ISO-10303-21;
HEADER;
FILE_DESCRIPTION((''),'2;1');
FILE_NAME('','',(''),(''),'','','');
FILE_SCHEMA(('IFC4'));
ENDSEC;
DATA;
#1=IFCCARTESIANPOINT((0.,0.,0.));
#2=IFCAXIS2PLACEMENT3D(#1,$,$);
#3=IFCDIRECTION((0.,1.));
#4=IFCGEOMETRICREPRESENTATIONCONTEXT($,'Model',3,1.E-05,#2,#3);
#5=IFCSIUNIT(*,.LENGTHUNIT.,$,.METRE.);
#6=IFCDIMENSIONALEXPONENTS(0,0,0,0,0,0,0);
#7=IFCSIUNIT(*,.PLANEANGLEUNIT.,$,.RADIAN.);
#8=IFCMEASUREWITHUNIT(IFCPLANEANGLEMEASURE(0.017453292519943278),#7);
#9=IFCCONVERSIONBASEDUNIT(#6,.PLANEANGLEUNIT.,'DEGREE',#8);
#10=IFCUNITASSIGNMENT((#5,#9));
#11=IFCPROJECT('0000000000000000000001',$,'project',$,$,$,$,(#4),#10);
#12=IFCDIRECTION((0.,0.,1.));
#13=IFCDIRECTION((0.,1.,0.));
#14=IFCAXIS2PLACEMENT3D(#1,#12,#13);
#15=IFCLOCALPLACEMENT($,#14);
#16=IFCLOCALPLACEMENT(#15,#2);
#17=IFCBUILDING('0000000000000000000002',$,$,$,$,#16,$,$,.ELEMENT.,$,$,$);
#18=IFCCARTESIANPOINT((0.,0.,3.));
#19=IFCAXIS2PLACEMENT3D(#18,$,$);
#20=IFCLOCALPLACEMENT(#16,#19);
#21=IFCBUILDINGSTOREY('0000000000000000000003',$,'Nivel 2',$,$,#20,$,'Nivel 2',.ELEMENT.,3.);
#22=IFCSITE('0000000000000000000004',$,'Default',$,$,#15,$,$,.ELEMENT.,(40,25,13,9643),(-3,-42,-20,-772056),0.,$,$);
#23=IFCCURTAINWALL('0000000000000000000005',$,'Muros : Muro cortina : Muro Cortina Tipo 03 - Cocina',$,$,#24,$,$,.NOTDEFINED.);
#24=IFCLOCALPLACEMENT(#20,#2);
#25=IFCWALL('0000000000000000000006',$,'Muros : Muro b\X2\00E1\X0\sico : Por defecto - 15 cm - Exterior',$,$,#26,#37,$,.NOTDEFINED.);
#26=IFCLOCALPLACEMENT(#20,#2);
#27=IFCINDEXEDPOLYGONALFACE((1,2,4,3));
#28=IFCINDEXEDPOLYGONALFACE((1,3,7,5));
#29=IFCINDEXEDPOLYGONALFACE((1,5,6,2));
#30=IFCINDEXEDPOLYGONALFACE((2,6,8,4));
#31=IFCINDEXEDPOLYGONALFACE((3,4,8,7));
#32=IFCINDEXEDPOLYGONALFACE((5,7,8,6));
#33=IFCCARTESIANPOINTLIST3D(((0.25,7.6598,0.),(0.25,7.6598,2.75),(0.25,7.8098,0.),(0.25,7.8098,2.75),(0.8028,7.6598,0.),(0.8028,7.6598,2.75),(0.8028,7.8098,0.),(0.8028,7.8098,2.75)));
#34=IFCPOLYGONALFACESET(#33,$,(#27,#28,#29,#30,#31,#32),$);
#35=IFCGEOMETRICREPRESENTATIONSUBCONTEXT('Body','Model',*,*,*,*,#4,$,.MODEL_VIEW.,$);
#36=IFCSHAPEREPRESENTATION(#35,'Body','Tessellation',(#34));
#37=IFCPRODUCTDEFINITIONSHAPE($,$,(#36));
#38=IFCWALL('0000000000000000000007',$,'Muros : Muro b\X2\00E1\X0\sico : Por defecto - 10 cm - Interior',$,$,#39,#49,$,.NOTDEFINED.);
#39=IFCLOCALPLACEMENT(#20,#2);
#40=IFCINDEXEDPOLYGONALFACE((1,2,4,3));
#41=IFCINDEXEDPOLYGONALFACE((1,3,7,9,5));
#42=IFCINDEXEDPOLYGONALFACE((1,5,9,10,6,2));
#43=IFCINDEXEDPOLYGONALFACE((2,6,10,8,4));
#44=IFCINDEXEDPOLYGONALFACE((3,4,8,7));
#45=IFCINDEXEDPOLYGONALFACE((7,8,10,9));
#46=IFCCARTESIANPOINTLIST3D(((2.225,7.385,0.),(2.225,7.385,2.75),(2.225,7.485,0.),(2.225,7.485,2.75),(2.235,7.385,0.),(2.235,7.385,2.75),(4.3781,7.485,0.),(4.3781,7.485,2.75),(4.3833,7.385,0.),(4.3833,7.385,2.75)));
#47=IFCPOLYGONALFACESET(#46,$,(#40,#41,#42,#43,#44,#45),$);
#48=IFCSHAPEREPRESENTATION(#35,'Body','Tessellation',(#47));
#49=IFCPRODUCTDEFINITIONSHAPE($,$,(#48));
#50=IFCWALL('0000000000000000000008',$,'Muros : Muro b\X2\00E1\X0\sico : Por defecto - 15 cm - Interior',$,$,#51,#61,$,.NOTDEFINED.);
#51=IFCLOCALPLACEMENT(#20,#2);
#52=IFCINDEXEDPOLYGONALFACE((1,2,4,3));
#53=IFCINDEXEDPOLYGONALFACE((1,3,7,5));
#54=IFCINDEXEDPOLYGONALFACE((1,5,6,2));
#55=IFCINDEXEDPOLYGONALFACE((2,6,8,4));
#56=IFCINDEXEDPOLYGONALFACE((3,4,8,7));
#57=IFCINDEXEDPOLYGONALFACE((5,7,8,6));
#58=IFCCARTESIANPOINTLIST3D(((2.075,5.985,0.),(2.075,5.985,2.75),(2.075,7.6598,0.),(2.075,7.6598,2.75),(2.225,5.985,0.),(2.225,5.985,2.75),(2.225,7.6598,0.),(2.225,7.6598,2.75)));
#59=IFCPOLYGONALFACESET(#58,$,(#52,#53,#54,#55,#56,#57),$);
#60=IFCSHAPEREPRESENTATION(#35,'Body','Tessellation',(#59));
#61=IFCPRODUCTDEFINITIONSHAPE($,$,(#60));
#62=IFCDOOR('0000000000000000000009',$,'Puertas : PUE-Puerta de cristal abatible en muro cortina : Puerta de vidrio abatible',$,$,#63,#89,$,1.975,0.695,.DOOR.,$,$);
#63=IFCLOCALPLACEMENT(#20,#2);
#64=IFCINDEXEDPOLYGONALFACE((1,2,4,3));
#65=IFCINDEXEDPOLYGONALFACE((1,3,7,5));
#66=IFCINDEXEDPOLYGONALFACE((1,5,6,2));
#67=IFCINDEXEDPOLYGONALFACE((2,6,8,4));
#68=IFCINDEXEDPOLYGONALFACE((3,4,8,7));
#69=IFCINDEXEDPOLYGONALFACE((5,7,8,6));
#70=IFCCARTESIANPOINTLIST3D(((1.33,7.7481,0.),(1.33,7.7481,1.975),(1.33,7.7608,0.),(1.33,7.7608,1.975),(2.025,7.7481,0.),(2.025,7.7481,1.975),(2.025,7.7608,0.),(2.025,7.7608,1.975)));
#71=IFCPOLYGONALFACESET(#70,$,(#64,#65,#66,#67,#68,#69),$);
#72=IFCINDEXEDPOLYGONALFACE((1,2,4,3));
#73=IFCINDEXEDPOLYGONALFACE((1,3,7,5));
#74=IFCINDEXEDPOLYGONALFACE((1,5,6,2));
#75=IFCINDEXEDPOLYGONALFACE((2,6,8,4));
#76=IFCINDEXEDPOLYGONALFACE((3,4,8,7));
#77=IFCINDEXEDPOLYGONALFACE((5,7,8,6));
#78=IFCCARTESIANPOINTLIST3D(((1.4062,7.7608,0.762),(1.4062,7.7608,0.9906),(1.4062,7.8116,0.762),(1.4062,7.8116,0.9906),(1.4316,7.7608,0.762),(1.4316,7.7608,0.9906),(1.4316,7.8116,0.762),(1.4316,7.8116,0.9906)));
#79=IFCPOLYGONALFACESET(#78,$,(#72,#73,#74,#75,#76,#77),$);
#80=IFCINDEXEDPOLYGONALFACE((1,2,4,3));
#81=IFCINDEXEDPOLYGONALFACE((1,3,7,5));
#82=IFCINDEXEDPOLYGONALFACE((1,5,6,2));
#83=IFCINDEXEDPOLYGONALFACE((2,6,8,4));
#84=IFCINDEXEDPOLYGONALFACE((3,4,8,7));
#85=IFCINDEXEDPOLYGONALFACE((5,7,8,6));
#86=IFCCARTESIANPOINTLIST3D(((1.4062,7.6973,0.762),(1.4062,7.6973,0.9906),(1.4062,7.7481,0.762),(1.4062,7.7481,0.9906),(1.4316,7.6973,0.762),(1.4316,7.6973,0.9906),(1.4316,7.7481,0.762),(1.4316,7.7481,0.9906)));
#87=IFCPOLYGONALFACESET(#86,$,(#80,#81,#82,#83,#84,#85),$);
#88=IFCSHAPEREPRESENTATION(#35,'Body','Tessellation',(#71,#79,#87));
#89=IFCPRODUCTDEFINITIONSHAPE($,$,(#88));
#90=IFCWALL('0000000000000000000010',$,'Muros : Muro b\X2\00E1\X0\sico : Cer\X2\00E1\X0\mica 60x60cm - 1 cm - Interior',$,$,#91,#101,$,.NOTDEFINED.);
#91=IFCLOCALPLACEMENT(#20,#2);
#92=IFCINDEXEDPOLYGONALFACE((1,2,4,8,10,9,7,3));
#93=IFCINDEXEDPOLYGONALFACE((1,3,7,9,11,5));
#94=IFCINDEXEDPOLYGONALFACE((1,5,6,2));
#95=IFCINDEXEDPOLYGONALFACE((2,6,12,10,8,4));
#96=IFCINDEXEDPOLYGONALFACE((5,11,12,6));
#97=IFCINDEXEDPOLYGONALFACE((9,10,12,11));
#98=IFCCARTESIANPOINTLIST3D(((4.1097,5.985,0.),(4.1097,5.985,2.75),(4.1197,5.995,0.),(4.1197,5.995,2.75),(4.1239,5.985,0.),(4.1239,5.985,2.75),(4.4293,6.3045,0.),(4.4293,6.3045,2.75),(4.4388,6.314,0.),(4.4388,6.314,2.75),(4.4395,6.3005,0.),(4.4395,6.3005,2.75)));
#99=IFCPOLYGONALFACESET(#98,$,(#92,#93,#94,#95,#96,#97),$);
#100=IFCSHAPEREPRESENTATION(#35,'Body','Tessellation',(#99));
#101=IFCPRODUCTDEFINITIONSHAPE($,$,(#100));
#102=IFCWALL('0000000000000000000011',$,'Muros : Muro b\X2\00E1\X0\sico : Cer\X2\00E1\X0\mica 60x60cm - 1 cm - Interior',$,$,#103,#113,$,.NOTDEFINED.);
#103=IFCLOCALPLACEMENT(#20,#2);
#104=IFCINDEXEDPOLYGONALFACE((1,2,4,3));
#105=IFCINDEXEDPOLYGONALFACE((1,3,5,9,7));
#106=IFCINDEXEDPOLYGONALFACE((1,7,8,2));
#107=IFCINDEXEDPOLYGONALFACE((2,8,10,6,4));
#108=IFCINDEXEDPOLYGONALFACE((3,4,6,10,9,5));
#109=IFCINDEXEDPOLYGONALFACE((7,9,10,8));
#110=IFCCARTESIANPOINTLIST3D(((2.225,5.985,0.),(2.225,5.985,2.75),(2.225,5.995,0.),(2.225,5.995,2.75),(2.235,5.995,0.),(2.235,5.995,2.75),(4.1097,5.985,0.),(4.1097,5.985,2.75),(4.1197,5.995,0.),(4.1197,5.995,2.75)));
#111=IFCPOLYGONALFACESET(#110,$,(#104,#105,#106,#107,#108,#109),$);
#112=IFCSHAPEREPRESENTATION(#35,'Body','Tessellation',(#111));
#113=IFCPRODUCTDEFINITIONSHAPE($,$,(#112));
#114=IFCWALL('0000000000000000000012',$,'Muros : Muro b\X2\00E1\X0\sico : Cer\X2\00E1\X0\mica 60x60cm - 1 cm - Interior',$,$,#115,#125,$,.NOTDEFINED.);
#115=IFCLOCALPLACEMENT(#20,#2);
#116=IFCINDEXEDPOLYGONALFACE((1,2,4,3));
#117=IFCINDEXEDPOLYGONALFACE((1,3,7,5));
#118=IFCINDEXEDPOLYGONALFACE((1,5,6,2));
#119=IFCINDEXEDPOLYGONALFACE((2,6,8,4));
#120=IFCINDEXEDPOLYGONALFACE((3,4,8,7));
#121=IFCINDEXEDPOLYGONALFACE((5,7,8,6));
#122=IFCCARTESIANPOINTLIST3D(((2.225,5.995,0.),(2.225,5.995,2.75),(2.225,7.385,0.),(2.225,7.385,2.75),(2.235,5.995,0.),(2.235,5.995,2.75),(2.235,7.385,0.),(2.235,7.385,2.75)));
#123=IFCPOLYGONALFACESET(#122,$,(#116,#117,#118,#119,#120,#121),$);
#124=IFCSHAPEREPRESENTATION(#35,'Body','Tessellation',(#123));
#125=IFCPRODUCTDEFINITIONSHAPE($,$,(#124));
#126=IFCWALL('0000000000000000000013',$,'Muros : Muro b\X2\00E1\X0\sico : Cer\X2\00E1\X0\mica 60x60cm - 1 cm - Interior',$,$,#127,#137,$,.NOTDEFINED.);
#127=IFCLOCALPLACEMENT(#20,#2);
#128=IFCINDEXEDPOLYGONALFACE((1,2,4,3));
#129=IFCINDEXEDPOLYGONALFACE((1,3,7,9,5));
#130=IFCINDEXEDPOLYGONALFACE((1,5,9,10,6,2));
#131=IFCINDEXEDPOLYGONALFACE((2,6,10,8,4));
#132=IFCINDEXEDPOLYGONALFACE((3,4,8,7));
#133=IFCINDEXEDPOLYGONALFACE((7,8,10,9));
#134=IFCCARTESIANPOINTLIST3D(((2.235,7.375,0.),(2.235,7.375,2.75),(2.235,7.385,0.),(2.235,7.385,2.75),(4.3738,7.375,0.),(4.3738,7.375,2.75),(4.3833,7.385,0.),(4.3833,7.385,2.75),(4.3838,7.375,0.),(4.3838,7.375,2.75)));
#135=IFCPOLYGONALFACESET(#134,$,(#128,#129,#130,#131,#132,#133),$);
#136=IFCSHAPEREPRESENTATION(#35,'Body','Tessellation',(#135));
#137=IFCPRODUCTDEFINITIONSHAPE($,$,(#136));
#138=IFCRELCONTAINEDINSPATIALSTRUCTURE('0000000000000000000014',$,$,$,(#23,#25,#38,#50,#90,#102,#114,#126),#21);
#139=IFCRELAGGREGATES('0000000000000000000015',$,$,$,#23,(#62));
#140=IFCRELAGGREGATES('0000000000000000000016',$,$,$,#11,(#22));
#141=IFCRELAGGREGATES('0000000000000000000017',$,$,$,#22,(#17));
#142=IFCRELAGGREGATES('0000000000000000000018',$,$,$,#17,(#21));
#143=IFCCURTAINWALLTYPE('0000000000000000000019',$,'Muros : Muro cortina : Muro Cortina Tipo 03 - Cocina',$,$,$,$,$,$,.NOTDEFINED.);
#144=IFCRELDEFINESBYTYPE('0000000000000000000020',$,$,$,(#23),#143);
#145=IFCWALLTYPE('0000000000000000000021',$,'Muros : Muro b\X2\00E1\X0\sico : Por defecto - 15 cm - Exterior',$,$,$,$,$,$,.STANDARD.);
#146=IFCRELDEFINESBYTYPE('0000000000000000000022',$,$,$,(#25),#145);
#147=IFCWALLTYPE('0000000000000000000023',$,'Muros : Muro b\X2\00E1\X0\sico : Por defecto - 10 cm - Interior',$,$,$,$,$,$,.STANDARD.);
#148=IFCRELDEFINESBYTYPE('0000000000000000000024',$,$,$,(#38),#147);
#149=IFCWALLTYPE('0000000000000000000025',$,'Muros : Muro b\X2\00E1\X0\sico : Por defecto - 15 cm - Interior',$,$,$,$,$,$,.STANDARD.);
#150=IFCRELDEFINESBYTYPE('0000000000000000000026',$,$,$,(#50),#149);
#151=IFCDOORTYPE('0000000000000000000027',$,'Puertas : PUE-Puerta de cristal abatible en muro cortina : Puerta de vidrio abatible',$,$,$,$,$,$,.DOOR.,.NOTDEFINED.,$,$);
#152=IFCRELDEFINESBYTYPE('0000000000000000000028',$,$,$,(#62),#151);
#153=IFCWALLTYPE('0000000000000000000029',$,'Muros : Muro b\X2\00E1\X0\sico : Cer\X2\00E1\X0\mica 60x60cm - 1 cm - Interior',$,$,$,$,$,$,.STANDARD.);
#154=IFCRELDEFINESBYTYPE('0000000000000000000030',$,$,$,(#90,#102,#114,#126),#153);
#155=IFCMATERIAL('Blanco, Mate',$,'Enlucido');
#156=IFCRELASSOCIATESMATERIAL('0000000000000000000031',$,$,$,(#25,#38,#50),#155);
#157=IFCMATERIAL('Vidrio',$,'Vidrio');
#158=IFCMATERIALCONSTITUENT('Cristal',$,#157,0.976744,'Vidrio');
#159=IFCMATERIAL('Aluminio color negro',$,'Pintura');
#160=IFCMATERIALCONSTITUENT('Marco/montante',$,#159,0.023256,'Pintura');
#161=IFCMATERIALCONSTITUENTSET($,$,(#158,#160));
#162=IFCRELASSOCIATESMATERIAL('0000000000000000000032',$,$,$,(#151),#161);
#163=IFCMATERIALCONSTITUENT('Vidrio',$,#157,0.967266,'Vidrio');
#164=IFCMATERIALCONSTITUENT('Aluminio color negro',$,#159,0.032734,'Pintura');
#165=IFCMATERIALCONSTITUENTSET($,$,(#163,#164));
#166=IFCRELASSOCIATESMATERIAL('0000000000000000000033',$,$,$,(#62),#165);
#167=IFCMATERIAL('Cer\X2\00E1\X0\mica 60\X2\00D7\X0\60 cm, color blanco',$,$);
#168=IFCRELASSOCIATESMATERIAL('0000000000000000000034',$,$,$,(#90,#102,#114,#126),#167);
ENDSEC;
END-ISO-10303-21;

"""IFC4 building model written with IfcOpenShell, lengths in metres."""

from ifc_helpers import new_model, entity, si_unit, converted_unit, direction, frame, origin, place, context, subcontext, project, spatial, indexed_curve, outline, extrude, source, transform, mapped, material, constituent, constituent_set, type_object, type_shapes, element, aggregate, save


model = new_model("IFC4")

# Units and contexts
model_context = context("Model", 3, precision=1e-05, world=origin(), true_north=direction((0.0, 1.0)))
body_context = subcontext(model_context, "Body", "Model", "MODEL_VIEW")
ifc_project = project(units=[si_unit("LENGTHUNIT", "METRE"), converted_unit("PLANEANGLEUNIT", "DEGREE", entity("IfcPlaneAngleMeasure", 0.017453292519943278), si_unit("PLANEANGLEUNIT", "RADIAN"), dimensions=[0, 0, 0, 0, 0, 0, 0])], contexts=[model_context])

# Site, building, storey
site_placement = place(None, frame((0.0, 0.0, 0.0), z_axis=(0.0, 0.0, 1.0), x_axis=(0.0, 1.0, 0.0)))
site = spatial("IfcSite", under=ifc_project, at=site_placement, Name="Default", CompositionType="ELEMENT", RefLatitude=(40, 25, 13, 9643), RefLongitude=(-3, -42, -20, -772056), RefElevation=0.0)
building_placement = place(site_placement, origin())
building = spatial("IfcBuilding", under=site, at=building_placement, CompositionType="ELEMENT")
storey_placement = place(building_placement, frame((0.0, 0.0, 3.0)))
storey = spatial("IfcBuildingStorey", under=building, at=storey_placement, Name="Nivel 2", LongName="Nivel 2", CompositionType="ELEMENT", Elevation=3.0)

# Shared definitions
ifc_material_1 = material(Name="Blanco, Mate", Category="Enlucido")

# Curtain wall
curtain_wall_type_1 = type_object("IfcCurtainWallType", Name="Muros : Muro cortina : Muro Cortina Tipo 03 - Cocina", PredefinedType="NOTDEFINED")
curtain_wall_1_placement = place(storey_placement, frame((0.0, 0.0, -3.0)))
curtain_wall_1 = element("IfcCurtainWall", 1, at=curtain_wall_1_placement, inside=storey, type_object=curtain_wall_type_1, Name="Muros : Muro cortina : Muro Cortina Tipo 03 - Cocina", PredefinedType="NOTDEFINED")
ifc_material_2 = material(Name="Aluminio color negro", Category="Pintura")
ifc_material_3 = material(Name="Vidrio", Category="Vidrio")

# Walls
wall_type_1 = type_object("IfcWallType", Name="Muros : Muro básico : Por defecto - 15 cm - Exterior", PredefinedType="STANDARD")
wall_1_placement = place(storey_placement, frame((0.25, 7.7348, 0.0)))
element("IfcWall", 2, at=wall_1_placement, inside=storey, type_object=wall_type_1, material=ifc_material_1, Name="Muros : Muro básico : Por defecto - 15 cm - Exterior", PredefinedType="NOTDEFINED", context=body_context, shape_type="SweptSolid", body=[
    extrude(outline(indexed_curve([(0.5528, 0.075), (0.0, 0.075), (0.0, -0.075), (0.5528, -0.075), (0.5528, 0.075)], self_intersect=False)), origin(), (0.0, 0.0, 1.0), 2.75),
])
wall_type_2 = type_object("IfcWallType", Name="Muros : Muro básico : Por defecto - 10 cm - Interior", PredefinedType="STANDARD")
wall_2_placement = place(storey_placement, frame((4.3833, 7.435, 0.0), z_axis=(0.0, 0.0, 1.0), x_axis=(-1.0, 0.0, 0.0)))
element("IfcWall", 3, at=wall_2_placement, inside=storey, type_object=wall_type_2, material=ifc_material_1, Name="Muros : Muro básico : Por defecto - 10 cm - Interior", PredefinedType="NOTDEFINED", context=body_context, shape_type="SweptSolid", body=[
    extrude(outline(indexed_curve([(2.1583, -0.05), (2.1583, 0.05), (2.1483, 0.05), (0.0, 0.05), (0.0052, -0.05), (2.1583, -0.05)], self_intersect=False)), origin(), (0.0, 0.0, 1.0), 2.75),
])
wall_type_3 = type_object("IfcWallType", Name="Muros : Muro básico : Por defecto - 15 cm - Interior", PredefinedType="STANDARD")
wall_3_placement = place(storey_placement, frame((2.15, 5.985, 0.0), z_axis=(0.0, 0.0, 1.0), x_axis=(0.0, 1.0, 0.0)))
element("IfcWall", 4, at=wall_3_placement, inside=storey, type_object=wall_type_3, material=ifc_material_1, Name="Muros : Muro básico : Por defecto - 15 cm - Interior", PredefinedType="NOTDEFINED", context=body_context, shape_type="SweptSolid", body=[
    extrude(outline(indexed_curve([(1.6748, 0.075), (0.0, 0.075), (0.0, -0.075), (1.6748, -0.075), (1.6748, 0.075)], self_intersect=False)), origin(), (0.0, 0.0, 1.0), 2.75),
])

# Door
ifc_constituent_1 = constituent(ifc_material_3, Name="Vidrio", Category="Vidrio", fraction=0.967266)
ifc_constituent_2 = constituent(ifc_material_2, Name="Aluminio color negro", Category="Pintura", fraction=0.032734)
ifc_constituent_set_1 = constituent_set(constituents=[ifc_constituent_1, ifc_constituent_2])
ifc_constituent_3 = constituent(ifc_material_3, Name="Cristal", Category="Vidrio", fraction=0.976744)
ifc_constituent_4 = constituent(ifc_material_2, Name="Marco/montante", Category="Pintura", fraction=0.023256)
ifc_constituent_set_2 = constituent_set(constituents=[ifc_constituent_3, ifc_constituent_4])
door_type = type_object("IfcDoorType", Name="Puertas : PUE-Puerta de cristal abatible en muro cortina : Puerta de vidrio abatible", OperationType="NOTDEFINED", PredefinedType="DOOR", material=ifc_constituent_set_2)
shared_shape_1 = source(origin(), body_context, "Body", "SweptSolid", [
    extrude(outline(indexed_curve([(-0.3475, -0.0064), (0.3475, -0.0064), (0.3475, 0.0064), (-0.3475, 0.0064), (-0.3475, -0.0064)], self_intersect=False)), frame((0.0, 0.0447, 0.0), z_axis=(0.0, 0.0, 1.0), x_axis=(-1.0, 0.0, 0.0)), (0.0, 0.0, 1.0), 1.975),
    extrude(outline(indexed_curve([(-0.0254, -0.0127), (0.0254, -0.0127), (0.0254, 0.0127), (-0.0254, 0.0127), (-0.0254, -0.0127)], self_intersect=False)), frame((-0.2586, 0.0764, 0.762), z_axis=(0.0, 0.0, 1.0), x_axis=(0.0, -1.0, 0.0)), (0.0, 0.0, 1.0), 0.2286),
    extrude(outline(indexed_curve([(-0.0254, -0.0127), (0.0254, -0.0127), (0.0254, 0.0127), (-0.0254, 0.0127), (-0.0254, -0.0127)], self_intersect=False)), frame((-0.2586, 0.0129, 0.762), z_axis=(0.0, 0.0, 1.0), x_axis=(0.0, 1.0, 0.0)), (0.0, 0.0, 1.0), 0.2286),
])
type_shapes(door_type, [shared_shape_1])
door_placement = place(curtain_wall_1_placement, frame((1.6775, 7.7098, 3.0)))
door = element("IfcDoor", 5, at=door_placement, type_object=door_type, material=ifc_constituent_set_1, Name="Puertas : PUE-Puerta de cristal abatible en muro cortina : Puerta de vidrio abatible", OverallHeight=1.975, OverallWidth=0.695, PredefinedType="DOOR", context=body_context, shape_type="MappedRepresentation", body=[
    mapped(shared_shape_1, transform((0.0, 0.0, 0.0), scale=1.0)),
])
aggregate(curtain_wall_1, [door])

# Walls
ifc_material_4 = material(Name="Cerámica 60×60 cm, color blanco")
wall_type_4 = type_object("IfcWallType", Name="Muros : Muro básico : Cerámica 60x60cm - 1 cm - Interior", PredefinedType="STANDARD")
wall_4_placement = place(storey_placement, frame((4.4424, 6.3105, 0.0), z_axis=(0.0, 0.0, 1.0), x_axis=(-0.707224, -0.706989, 0.0)))
element("IfcWall", 6, at=wall_4_placement, inside=storey, type_object=wall_type_4, material=ifc_material_4, Name="Muros : Muro básico : Cerámica 60x60cm - 1 cm - Interior", PredefinedType="NOTDEFINED", context=body_context, shape_type="SweptSolid", body=[
    extrude(outline(indexed_curve([(0.4653, -0.005), (0.4553, 0.005), (0.009, 0.005), (0.0, -0.005), (0.0135, -0.005), (0.4512, -0.005), (0.4653, -0.005)], self_intersect=False)), origin(), (0.0, 0.0, 1.0), 2.75),
])
wall_5_placement = place(storey_placement, frame((4.1197, 5.99, 0.0), z_axis=(0.0, 0.0, 1.0), x_axis=(-1.0, 0.0, 0.0)))
element("IfcWall", 7, at=wall_5_placement, inside=storey, type_object=wall_type_4, material=ifc_material_4, Name="Muros : Muro básico : Cerámica 60x60cm - 1 cm - Interior", PredefinedType="NOTDEFINED", context=body_context, shape_type="SweptSolid", body=[
    extrude(outline(indexed_curve([(1.8947, -0.005), (1.8947, 0.005), (0.01, 0.005), (0.0, -0.005), (1.8847, -0.005), (1.8947, -0.005)], self_intersect=False)), origin(), (0.0, 0.0, 1.0), 2.75),
])
wall_6_placement = place(storey_placement, frame((2.23, 5.995, 0.0), z_axis=(0.0, 0.0, 1.0), x_axis=(0.0, 1.0, 0.0)))
element("IfcWall", 8, at=wall_6_placement, inside=storey, type_object=wall_type_4, material=ifc_material_4, Name="Muros : Muro básico : Cerámica 60x60cm - 1 cm - Interior", PredefinedType="NOTDEFINED", context=body_context, shape_type="SweptSolid", body=[
    extrude(outline(indexed_curve([(1.39, 0.005), (0.0, 0.005), (0.0, -0.005), (1.39, -0.005), (1.39, 0.005)], self_intersect=False)), origin(), (0.0, 0.0, 1.0), 2.75),
])
wall_7_placement = place(storey_placement, frame((2.235, 7.38, 0.0)))
element("IfcWall", 9, at=wall_7_placement, inside=storey, type_object=wall_type_4, material=ifc_material_4, Name="Muros : Muro básico : Cerámica 60x60cm - 1 cm - Interior", PredefinedType="NOTDEFINED", context=body_context, shape_type="SweptSolid", body=[
    extrude(outline(indexed_curve([(2.1488, -0.005), (2.1483, 0.005), (0.0, 0.005), (0.0, -0.005), (2.1388, -0.005), (2.1488, -0.005)], self_intersect=False)), origin(), (0.0, 0.0, 1.0), 2.75),
])

save(model, "model.ifc")
